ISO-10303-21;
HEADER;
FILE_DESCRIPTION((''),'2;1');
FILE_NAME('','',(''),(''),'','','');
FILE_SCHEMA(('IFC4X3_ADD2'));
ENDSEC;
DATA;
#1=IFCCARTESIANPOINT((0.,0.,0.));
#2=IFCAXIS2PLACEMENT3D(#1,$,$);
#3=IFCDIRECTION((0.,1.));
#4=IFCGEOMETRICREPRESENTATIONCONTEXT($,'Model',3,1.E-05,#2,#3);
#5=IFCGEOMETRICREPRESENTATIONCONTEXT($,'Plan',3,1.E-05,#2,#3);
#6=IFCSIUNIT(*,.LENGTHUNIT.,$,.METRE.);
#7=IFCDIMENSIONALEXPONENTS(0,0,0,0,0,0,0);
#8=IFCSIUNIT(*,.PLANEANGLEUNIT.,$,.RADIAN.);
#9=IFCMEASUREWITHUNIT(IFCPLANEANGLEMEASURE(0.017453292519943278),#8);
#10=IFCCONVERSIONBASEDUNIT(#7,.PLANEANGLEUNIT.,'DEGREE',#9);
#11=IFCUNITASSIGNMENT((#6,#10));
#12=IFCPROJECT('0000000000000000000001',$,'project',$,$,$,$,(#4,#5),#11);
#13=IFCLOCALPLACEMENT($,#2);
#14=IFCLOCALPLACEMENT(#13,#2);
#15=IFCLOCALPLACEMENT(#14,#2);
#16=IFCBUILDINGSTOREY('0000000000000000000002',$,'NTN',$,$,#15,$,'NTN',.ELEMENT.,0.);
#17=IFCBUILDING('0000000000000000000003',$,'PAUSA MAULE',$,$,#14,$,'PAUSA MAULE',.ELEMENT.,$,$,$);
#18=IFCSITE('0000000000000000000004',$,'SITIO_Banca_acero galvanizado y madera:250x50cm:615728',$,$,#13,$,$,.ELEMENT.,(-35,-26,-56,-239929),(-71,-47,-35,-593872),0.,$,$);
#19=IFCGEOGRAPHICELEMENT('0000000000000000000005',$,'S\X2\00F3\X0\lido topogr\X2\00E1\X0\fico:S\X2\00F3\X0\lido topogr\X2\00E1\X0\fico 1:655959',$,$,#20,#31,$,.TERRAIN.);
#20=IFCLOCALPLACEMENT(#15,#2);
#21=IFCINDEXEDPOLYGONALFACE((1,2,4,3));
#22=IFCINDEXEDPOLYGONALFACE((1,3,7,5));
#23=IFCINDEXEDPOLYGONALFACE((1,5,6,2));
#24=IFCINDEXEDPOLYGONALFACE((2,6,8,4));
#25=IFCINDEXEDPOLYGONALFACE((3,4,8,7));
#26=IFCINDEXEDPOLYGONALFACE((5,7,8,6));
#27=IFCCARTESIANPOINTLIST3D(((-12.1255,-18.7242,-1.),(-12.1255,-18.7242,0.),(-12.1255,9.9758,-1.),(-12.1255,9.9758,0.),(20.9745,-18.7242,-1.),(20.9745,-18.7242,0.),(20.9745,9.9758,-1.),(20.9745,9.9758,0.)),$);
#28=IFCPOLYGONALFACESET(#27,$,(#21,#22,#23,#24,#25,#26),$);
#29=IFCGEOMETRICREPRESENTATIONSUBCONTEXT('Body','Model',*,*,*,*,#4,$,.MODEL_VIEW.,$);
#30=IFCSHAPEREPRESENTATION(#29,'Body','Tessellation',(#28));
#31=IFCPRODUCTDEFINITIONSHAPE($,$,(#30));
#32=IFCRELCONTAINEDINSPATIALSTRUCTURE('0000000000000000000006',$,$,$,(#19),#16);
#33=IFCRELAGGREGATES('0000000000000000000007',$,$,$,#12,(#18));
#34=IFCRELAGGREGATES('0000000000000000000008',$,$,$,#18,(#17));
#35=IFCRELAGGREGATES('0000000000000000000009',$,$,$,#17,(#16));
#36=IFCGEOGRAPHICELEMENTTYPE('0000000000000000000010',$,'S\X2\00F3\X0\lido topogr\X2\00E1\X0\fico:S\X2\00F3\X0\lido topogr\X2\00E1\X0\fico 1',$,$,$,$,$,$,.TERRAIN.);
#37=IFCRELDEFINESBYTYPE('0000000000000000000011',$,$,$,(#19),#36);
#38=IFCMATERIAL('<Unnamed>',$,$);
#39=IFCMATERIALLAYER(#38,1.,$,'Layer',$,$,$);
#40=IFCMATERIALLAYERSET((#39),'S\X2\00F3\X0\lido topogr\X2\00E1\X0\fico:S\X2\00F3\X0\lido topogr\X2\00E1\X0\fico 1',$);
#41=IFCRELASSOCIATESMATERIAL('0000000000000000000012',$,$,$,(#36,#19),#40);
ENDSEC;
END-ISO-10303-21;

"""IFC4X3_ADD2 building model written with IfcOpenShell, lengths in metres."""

from ifc_helpers import new_model, entity, si_unit, converted_unit, direction, frame, origin, origin_2d_with_axis, place, context, subcontext, project, spatial, rectangle, extrude, material, layer, layer_set, layer_usage, type_object, element, save


model = new_model("IFC4X3_ADD2")

# Units and contexts
model_context = context("Model", 3, precision=1e-05, world=origin(), true_north=direction((0.0, 1.0)))
plan_context = context("Plan", 3, precision=1e-05, world=origin(), true_north=direction((0.0, 1.0)))
body_context = subcontext(model_context, "Body", "Model", "MODEL_VIEW")
ifc_project = project(units=[si_unit("LENGTHUNIT", "METRE"), converted_unit("PLANEANGLEUNIT", "DEGREE", entity("IfcPlaneAngleMeasure", 0.017453292519943278), si_unit("PLANEANGLEUNIT", "RADIAN"), dimensions=[0, 0, 0, 0, 0, 0, 0])], contexts=[model_context, plan_context])

# Site, building, storey
site_placement = place(None, origin())
site = spatial("IfcSite", under=ifc_project, at=site_placement, Name="SITIO_Banca_acero galvanizado y madera:250x50cm:615728", CompositionType="ELEMENT", RefLatitude=(-35, -26, -56, -239929), RefLongitude=(-71, -47, -35, -593872), RefElevation=0.0)
building_placement = place(site_placement, origin())
building = spatial("IfcBuilding", under=site, at=building_placement, Name="PAUSA MAULE", LongName="PAUSA MAULE", CompositionType="ELEMENT")
storey_placement = place(building_placement, origin())
storey = spatial("IfcBuildingStorey", under=building, at=storey_placement, Name="NTN", LongName="NTN", CompositionType="ELEMENT", Elevation=0.0)

# Geographic element
ifc_material = material(Name="<Unnamed>")
ifc_layer = layer(ifc_material, 1.0, Name="Layer")
ifc_layer_set = layer_set([ifc_layer], Name="Sólido topográfico:Sólido topográfico 1")
ifc_layer_usage = layer_usage(ifc_layer_set, "AXIS3", "NEGATIVE", 0.0)
geographic_element_type = type_object("IfcGeographicElementType", Name="Sólido topográfico:Sólido topográfico 1", PredefinedType="TERRAIN", material=ifc_layer_set)
geographic_element_placement = place(storey_placement, origin())
element("IfcGeographicElement", 1, at=geographic_element_placement, inside=storey, type_object=geographic_element_type, material=ifc_layer_usage, Name="Sólido topográfico:Sólido topográfico 1:655959", PredefinedType="TERRAIN", context=body_context, shape_type="SweptSolid", body=[
    extrude(rectangle(XDim=28.7, YDim=33.1, at=origin_2d_with_axis()), frame((4.4245, -4.3742, -1.0), z_axis=(0.0, 0.0, 1.0), x_axis=(0.0, -1.0, 0.0)), (0.0, 0.0, 1.0), 1.0),
])

save(model, "model.ifc")
